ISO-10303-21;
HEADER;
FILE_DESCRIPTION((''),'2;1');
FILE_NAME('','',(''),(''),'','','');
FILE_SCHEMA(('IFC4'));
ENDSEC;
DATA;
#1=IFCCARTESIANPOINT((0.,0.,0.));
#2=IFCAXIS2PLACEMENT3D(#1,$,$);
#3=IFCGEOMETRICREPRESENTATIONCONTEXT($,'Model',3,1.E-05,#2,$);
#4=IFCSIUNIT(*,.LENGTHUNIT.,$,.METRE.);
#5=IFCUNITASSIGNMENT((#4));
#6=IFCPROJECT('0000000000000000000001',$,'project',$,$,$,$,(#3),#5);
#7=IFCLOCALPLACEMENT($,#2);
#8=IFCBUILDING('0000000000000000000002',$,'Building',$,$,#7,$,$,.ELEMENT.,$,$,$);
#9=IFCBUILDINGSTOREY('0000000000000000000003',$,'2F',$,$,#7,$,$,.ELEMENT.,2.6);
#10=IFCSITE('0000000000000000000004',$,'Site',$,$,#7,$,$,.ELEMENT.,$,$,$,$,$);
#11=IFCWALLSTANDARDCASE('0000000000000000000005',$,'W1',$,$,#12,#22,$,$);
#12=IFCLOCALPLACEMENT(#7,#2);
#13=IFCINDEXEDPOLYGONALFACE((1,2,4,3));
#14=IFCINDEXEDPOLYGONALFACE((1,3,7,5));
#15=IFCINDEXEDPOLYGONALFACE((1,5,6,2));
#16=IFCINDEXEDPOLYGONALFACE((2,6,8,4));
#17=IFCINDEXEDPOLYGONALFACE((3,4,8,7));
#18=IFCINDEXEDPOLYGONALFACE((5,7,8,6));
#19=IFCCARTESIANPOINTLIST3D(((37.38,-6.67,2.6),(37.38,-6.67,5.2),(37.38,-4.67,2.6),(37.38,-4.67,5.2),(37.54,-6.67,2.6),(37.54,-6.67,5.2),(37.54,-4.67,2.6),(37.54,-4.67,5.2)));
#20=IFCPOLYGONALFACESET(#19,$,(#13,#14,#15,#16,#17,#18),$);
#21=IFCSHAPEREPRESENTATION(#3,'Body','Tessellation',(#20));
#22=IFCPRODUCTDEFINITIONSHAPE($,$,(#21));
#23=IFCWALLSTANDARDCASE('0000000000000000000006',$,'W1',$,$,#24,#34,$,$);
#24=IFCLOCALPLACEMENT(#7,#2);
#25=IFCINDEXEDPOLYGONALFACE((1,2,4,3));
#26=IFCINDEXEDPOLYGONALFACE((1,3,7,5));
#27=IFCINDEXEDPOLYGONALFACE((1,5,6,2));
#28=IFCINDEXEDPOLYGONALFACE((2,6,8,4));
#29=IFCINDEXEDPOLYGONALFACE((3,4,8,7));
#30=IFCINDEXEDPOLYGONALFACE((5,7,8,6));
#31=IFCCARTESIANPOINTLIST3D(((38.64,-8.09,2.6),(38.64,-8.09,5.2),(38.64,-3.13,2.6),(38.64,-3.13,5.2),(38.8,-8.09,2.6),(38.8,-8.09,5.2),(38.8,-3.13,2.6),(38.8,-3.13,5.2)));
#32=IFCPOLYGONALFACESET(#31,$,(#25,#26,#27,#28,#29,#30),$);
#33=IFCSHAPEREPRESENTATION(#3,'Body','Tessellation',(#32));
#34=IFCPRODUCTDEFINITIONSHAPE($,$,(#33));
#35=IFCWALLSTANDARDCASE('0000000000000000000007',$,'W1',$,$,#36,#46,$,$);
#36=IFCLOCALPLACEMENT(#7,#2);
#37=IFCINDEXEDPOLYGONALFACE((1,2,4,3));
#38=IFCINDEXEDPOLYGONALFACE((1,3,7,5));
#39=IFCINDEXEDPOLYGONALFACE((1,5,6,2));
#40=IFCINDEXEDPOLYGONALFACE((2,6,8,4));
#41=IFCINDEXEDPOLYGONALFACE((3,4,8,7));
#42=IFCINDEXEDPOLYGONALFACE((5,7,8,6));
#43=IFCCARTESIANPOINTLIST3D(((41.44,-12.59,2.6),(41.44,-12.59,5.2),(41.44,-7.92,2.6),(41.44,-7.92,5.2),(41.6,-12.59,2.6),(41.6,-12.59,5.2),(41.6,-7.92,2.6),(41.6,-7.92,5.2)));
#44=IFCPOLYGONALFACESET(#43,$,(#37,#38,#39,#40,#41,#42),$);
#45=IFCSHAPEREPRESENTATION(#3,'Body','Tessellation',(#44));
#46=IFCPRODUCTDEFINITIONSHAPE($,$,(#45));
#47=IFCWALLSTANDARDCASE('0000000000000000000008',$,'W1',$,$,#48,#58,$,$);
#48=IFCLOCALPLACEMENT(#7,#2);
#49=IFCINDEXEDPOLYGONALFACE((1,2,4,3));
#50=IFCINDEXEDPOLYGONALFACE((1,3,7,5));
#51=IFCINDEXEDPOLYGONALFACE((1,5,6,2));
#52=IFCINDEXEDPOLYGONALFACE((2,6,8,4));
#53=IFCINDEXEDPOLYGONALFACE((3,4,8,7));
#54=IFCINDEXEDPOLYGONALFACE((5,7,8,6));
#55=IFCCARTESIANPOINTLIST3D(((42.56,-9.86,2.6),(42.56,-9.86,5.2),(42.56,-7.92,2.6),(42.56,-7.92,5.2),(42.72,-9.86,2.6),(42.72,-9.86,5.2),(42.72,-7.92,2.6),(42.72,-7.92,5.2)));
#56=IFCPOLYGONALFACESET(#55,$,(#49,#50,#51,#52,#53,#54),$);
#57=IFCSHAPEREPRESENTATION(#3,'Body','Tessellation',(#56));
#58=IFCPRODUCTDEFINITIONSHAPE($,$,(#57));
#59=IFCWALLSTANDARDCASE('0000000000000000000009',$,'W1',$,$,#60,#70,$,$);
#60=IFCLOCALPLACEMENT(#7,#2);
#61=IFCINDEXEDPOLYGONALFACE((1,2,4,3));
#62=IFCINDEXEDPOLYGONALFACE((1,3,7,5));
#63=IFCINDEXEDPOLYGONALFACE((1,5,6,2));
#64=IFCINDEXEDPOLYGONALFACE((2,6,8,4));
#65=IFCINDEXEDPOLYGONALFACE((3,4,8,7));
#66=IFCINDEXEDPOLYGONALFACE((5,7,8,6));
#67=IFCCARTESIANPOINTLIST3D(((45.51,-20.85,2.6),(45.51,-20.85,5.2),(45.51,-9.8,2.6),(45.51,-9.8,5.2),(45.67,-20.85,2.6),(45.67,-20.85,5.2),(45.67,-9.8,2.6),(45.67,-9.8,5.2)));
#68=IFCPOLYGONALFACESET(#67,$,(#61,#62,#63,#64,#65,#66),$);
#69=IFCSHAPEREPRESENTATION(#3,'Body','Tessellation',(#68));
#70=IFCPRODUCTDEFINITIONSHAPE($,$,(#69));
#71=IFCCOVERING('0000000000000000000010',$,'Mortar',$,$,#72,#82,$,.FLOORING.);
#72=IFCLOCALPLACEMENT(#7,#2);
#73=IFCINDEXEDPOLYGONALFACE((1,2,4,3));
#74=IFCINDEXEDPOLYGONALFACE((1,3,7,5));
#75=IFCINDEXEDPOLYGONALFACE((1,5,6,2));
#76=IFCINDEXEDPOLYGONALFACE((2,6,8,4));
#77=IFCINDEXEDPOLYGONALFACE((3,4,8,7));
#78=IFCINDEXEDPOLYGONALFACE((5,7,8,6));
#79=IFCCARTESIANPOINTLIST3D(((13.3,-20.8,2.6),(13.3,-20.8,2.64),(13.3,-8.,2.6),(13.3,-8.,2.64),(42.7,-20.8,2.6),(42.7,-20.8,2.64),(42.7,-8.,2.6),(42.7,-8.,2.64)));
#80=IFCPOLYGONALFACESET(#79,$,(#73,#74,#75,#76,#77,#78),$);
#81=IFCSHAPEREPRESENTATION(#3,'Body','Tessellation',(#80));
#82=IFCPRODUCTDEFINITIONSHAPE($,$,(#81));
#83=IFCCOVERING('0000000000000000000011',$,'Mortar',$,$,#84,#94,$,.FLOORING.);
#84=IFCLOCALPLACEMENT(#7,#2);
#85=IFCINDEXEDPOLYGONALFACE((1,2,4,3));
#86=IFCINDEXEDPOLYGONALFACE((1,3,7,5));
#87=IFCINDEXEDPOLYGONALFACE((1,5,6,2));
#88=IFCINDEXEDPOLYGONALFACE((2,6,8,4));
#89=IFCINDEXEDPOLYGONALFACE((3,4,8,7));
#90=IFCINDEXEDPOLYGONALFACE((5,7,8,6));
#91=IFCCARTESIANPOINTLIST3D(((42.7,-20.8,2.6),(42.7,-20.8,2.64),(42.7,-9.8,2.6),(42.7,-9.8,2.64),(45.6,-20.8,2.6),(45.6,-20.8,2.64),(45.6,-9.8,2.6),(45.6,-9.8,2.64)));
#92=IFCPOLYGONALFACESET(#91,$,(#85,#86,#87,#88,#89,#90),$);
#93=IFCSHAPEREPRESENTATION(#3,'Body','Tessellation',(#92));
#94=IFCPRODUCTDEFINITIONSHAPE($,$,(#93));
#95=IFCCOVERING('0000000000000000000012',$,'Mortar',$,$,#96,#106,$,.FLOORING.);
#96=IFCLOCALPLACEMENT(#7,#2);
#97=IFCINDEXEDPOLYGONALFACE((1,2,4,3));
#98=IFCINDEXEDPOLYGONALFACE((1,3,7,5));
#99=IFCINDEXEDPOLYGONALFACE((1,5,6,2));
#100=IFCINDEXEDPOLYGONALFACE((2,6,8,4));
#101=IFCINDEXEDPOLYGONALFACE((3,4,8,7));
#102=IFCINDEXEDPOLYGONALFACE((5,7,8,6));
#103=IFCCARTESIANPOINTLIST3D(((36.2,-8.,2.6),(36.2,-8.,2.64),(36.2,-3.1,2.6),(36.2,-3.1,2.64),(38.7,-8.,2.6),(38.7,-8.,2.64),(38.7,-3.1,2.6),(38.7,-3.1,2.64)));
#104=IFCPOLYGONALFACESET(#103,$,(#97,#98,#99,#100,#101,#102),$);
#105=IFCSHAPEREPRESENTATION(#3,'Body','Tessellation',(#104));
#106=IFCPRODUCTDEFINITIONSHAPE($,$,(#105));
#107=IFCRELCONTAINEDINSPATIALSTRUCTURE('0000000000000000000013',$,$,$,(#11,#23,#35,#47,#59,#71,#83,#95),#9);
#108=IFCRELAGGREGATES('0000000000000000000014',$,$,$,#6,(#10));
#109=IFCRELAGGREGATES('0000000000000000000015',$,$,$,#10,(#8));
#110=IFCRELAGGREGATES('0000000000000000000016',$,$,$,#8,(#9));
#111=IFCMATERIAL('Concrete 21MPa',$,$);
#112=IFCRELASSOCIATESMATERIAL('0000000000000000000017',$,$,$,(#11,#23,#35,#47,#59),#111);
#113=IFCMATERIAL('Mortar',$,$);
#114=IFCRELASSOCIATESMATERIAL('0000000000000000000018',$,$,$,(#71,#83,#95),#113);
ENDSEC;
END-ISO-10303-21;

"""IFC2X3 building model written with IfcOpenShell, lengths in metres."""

from ifc_helpers import new_model, si_unit, frame, origin, origin_2d, place, context, project, spatial, rectangle, extrude, material, element, save


model = new_model("IFC2X3")

# Units and contexts
model_context = context("Model", 3, precision=1e-05, world=origin())
ifc_project = project(units=[si_unit("LENGTHUNIT", "METRE")], contexts=[model_context])

# Site, building, storey
placement = place(None, origin())
site = spatial("IfcSite", under=ifc_project, at=placement, Name="Site", CompositionType="ELEMENT")
building = spatial("IfcBuilding", under=site, at=placement, Name="Building", CompositionType="ELEMENT")
storey = spatial("IfcBuildingStorey", under=building, at=placement, Name="2F", CompositionType="ELEMENT", Elevation=2.6)

# Shared definitions
ifc_material_1 = material(Name="Concrete 21MPa")

# Walls
wall_1_placement = place(None, frame((37.46, -5.67, 2.6)))
element("IfcWallStandardCase", 1, at=wall_1_placement, inside=storey, material=ifc_material_1, Name="W1", context=model_context, shape_type="SweptSolid", body=[
    extrude(rectangle(XDim=0.16, YDim=2.0, at=origin_2d()), origin(), (0.0, 0.0, 1.0), 2.6),
])
wall_2_placement = place(None, frame((38.72, -5.61, 2.6)))
element("IfcWallStandardCase", 2, at=wall_2_placement, inside=storey, material=ifc_material_1, Name="W1", context=model_context, shape_type="SweptSolid", body=[
    extrude(rectangle(XDim=0.16, YDim=4.96, at=origin_2d()), origin(), (0.0, 0.0, 1.0), 2.6),
])
wall_3_placement = place(None, frame((41.52, -10.255, 2.6)))
element("IfcWallStandardCase", 3, at=wall_3_placement, inside=storey, material=ifc_material_1, Name="W1", context=model_context, shape_type="SweptSolid", body=[
    extrude(rectangle(XDim=0.16, YDim=4.67, at=origin_2d()), origin(), (0.0, 0.0, 1.0), 2.6),
])
wall_4_placement = place(None, frame((42.64, -8.89, 2.6)))
element("IfcWallStandardCase", 4, at=wall_4_placement, inside=storey, material=ifc_material_1, Name="W1", context=model_context, shape_type="SweptSolid", body=[
    extrude(rectangle(XDim=0.16, YDim=1.94, at=origin_2d()), origin(), (0.0, 0.0, 1.0), 2.6),
])
wall_5_placement = place(None, frame((45.59, -15.325, 2.6)))
element("IfcWallStandardCase", 5, at=wall_5_placement, inside=storey, material=ifc_material_1, Name="W1", context=model_context, shape_type="SweptSolid", body=[
    extrude(rectangle(XDim=0.16, YDim=11.05, at=origin_2d()), origin(), (0.0, 0.0, 1.0), 2.6),
])

# Coverings
ifc_material_2 = material(Name="Mortar")
covering_1_placement = place(None, frame((28.0, -14.4, 2.6)))
element("IfcCovering", 6, at=covering_1_placement, inside=storey, material=ifc_material_2, Name="Mortar", PredefinedType="FLOORING", context=model_context, shape_type="SweptSolid", body=[
    extrude(rectangle(XDim=29.4, YDim=12.8, at=origin_2d()), origin(), (0.0, 0.0, 1.0), 0.04),
])
covering_2_placement = place(None, frame((44.15, -15.3, 2.6)))
element("IfcCovering", 7, at=covering_2_placement, inside=storey, material=ifc_material_2, Name="Mortar", PredefinedType="FLOORING", context=model_context, shape_type="SweptSolid", body=[
    extrude(rectangle(XDim=2.9, YDim=11.0, at=origin_2d()), origin(), (0.0, 0.0, 1.0), 0.04),
])
covering_3_placement = place(None, frame((37.45, -5.55, 2.6)))
element("IfcCovering", 8, at=covering_3_placement, inside=storey, material=ifc_material_2, Name="Mortar", PredefinedType="FLOORING", context=model_context, shape_type="SweptSolid", body=[
    extrude(rectangle(XDim=2.5, YDim=4.9, at=origin_2d()), origin(), (0.0, 0.0, 1.0), 0.04),
])

save(model, "model.ifc")
